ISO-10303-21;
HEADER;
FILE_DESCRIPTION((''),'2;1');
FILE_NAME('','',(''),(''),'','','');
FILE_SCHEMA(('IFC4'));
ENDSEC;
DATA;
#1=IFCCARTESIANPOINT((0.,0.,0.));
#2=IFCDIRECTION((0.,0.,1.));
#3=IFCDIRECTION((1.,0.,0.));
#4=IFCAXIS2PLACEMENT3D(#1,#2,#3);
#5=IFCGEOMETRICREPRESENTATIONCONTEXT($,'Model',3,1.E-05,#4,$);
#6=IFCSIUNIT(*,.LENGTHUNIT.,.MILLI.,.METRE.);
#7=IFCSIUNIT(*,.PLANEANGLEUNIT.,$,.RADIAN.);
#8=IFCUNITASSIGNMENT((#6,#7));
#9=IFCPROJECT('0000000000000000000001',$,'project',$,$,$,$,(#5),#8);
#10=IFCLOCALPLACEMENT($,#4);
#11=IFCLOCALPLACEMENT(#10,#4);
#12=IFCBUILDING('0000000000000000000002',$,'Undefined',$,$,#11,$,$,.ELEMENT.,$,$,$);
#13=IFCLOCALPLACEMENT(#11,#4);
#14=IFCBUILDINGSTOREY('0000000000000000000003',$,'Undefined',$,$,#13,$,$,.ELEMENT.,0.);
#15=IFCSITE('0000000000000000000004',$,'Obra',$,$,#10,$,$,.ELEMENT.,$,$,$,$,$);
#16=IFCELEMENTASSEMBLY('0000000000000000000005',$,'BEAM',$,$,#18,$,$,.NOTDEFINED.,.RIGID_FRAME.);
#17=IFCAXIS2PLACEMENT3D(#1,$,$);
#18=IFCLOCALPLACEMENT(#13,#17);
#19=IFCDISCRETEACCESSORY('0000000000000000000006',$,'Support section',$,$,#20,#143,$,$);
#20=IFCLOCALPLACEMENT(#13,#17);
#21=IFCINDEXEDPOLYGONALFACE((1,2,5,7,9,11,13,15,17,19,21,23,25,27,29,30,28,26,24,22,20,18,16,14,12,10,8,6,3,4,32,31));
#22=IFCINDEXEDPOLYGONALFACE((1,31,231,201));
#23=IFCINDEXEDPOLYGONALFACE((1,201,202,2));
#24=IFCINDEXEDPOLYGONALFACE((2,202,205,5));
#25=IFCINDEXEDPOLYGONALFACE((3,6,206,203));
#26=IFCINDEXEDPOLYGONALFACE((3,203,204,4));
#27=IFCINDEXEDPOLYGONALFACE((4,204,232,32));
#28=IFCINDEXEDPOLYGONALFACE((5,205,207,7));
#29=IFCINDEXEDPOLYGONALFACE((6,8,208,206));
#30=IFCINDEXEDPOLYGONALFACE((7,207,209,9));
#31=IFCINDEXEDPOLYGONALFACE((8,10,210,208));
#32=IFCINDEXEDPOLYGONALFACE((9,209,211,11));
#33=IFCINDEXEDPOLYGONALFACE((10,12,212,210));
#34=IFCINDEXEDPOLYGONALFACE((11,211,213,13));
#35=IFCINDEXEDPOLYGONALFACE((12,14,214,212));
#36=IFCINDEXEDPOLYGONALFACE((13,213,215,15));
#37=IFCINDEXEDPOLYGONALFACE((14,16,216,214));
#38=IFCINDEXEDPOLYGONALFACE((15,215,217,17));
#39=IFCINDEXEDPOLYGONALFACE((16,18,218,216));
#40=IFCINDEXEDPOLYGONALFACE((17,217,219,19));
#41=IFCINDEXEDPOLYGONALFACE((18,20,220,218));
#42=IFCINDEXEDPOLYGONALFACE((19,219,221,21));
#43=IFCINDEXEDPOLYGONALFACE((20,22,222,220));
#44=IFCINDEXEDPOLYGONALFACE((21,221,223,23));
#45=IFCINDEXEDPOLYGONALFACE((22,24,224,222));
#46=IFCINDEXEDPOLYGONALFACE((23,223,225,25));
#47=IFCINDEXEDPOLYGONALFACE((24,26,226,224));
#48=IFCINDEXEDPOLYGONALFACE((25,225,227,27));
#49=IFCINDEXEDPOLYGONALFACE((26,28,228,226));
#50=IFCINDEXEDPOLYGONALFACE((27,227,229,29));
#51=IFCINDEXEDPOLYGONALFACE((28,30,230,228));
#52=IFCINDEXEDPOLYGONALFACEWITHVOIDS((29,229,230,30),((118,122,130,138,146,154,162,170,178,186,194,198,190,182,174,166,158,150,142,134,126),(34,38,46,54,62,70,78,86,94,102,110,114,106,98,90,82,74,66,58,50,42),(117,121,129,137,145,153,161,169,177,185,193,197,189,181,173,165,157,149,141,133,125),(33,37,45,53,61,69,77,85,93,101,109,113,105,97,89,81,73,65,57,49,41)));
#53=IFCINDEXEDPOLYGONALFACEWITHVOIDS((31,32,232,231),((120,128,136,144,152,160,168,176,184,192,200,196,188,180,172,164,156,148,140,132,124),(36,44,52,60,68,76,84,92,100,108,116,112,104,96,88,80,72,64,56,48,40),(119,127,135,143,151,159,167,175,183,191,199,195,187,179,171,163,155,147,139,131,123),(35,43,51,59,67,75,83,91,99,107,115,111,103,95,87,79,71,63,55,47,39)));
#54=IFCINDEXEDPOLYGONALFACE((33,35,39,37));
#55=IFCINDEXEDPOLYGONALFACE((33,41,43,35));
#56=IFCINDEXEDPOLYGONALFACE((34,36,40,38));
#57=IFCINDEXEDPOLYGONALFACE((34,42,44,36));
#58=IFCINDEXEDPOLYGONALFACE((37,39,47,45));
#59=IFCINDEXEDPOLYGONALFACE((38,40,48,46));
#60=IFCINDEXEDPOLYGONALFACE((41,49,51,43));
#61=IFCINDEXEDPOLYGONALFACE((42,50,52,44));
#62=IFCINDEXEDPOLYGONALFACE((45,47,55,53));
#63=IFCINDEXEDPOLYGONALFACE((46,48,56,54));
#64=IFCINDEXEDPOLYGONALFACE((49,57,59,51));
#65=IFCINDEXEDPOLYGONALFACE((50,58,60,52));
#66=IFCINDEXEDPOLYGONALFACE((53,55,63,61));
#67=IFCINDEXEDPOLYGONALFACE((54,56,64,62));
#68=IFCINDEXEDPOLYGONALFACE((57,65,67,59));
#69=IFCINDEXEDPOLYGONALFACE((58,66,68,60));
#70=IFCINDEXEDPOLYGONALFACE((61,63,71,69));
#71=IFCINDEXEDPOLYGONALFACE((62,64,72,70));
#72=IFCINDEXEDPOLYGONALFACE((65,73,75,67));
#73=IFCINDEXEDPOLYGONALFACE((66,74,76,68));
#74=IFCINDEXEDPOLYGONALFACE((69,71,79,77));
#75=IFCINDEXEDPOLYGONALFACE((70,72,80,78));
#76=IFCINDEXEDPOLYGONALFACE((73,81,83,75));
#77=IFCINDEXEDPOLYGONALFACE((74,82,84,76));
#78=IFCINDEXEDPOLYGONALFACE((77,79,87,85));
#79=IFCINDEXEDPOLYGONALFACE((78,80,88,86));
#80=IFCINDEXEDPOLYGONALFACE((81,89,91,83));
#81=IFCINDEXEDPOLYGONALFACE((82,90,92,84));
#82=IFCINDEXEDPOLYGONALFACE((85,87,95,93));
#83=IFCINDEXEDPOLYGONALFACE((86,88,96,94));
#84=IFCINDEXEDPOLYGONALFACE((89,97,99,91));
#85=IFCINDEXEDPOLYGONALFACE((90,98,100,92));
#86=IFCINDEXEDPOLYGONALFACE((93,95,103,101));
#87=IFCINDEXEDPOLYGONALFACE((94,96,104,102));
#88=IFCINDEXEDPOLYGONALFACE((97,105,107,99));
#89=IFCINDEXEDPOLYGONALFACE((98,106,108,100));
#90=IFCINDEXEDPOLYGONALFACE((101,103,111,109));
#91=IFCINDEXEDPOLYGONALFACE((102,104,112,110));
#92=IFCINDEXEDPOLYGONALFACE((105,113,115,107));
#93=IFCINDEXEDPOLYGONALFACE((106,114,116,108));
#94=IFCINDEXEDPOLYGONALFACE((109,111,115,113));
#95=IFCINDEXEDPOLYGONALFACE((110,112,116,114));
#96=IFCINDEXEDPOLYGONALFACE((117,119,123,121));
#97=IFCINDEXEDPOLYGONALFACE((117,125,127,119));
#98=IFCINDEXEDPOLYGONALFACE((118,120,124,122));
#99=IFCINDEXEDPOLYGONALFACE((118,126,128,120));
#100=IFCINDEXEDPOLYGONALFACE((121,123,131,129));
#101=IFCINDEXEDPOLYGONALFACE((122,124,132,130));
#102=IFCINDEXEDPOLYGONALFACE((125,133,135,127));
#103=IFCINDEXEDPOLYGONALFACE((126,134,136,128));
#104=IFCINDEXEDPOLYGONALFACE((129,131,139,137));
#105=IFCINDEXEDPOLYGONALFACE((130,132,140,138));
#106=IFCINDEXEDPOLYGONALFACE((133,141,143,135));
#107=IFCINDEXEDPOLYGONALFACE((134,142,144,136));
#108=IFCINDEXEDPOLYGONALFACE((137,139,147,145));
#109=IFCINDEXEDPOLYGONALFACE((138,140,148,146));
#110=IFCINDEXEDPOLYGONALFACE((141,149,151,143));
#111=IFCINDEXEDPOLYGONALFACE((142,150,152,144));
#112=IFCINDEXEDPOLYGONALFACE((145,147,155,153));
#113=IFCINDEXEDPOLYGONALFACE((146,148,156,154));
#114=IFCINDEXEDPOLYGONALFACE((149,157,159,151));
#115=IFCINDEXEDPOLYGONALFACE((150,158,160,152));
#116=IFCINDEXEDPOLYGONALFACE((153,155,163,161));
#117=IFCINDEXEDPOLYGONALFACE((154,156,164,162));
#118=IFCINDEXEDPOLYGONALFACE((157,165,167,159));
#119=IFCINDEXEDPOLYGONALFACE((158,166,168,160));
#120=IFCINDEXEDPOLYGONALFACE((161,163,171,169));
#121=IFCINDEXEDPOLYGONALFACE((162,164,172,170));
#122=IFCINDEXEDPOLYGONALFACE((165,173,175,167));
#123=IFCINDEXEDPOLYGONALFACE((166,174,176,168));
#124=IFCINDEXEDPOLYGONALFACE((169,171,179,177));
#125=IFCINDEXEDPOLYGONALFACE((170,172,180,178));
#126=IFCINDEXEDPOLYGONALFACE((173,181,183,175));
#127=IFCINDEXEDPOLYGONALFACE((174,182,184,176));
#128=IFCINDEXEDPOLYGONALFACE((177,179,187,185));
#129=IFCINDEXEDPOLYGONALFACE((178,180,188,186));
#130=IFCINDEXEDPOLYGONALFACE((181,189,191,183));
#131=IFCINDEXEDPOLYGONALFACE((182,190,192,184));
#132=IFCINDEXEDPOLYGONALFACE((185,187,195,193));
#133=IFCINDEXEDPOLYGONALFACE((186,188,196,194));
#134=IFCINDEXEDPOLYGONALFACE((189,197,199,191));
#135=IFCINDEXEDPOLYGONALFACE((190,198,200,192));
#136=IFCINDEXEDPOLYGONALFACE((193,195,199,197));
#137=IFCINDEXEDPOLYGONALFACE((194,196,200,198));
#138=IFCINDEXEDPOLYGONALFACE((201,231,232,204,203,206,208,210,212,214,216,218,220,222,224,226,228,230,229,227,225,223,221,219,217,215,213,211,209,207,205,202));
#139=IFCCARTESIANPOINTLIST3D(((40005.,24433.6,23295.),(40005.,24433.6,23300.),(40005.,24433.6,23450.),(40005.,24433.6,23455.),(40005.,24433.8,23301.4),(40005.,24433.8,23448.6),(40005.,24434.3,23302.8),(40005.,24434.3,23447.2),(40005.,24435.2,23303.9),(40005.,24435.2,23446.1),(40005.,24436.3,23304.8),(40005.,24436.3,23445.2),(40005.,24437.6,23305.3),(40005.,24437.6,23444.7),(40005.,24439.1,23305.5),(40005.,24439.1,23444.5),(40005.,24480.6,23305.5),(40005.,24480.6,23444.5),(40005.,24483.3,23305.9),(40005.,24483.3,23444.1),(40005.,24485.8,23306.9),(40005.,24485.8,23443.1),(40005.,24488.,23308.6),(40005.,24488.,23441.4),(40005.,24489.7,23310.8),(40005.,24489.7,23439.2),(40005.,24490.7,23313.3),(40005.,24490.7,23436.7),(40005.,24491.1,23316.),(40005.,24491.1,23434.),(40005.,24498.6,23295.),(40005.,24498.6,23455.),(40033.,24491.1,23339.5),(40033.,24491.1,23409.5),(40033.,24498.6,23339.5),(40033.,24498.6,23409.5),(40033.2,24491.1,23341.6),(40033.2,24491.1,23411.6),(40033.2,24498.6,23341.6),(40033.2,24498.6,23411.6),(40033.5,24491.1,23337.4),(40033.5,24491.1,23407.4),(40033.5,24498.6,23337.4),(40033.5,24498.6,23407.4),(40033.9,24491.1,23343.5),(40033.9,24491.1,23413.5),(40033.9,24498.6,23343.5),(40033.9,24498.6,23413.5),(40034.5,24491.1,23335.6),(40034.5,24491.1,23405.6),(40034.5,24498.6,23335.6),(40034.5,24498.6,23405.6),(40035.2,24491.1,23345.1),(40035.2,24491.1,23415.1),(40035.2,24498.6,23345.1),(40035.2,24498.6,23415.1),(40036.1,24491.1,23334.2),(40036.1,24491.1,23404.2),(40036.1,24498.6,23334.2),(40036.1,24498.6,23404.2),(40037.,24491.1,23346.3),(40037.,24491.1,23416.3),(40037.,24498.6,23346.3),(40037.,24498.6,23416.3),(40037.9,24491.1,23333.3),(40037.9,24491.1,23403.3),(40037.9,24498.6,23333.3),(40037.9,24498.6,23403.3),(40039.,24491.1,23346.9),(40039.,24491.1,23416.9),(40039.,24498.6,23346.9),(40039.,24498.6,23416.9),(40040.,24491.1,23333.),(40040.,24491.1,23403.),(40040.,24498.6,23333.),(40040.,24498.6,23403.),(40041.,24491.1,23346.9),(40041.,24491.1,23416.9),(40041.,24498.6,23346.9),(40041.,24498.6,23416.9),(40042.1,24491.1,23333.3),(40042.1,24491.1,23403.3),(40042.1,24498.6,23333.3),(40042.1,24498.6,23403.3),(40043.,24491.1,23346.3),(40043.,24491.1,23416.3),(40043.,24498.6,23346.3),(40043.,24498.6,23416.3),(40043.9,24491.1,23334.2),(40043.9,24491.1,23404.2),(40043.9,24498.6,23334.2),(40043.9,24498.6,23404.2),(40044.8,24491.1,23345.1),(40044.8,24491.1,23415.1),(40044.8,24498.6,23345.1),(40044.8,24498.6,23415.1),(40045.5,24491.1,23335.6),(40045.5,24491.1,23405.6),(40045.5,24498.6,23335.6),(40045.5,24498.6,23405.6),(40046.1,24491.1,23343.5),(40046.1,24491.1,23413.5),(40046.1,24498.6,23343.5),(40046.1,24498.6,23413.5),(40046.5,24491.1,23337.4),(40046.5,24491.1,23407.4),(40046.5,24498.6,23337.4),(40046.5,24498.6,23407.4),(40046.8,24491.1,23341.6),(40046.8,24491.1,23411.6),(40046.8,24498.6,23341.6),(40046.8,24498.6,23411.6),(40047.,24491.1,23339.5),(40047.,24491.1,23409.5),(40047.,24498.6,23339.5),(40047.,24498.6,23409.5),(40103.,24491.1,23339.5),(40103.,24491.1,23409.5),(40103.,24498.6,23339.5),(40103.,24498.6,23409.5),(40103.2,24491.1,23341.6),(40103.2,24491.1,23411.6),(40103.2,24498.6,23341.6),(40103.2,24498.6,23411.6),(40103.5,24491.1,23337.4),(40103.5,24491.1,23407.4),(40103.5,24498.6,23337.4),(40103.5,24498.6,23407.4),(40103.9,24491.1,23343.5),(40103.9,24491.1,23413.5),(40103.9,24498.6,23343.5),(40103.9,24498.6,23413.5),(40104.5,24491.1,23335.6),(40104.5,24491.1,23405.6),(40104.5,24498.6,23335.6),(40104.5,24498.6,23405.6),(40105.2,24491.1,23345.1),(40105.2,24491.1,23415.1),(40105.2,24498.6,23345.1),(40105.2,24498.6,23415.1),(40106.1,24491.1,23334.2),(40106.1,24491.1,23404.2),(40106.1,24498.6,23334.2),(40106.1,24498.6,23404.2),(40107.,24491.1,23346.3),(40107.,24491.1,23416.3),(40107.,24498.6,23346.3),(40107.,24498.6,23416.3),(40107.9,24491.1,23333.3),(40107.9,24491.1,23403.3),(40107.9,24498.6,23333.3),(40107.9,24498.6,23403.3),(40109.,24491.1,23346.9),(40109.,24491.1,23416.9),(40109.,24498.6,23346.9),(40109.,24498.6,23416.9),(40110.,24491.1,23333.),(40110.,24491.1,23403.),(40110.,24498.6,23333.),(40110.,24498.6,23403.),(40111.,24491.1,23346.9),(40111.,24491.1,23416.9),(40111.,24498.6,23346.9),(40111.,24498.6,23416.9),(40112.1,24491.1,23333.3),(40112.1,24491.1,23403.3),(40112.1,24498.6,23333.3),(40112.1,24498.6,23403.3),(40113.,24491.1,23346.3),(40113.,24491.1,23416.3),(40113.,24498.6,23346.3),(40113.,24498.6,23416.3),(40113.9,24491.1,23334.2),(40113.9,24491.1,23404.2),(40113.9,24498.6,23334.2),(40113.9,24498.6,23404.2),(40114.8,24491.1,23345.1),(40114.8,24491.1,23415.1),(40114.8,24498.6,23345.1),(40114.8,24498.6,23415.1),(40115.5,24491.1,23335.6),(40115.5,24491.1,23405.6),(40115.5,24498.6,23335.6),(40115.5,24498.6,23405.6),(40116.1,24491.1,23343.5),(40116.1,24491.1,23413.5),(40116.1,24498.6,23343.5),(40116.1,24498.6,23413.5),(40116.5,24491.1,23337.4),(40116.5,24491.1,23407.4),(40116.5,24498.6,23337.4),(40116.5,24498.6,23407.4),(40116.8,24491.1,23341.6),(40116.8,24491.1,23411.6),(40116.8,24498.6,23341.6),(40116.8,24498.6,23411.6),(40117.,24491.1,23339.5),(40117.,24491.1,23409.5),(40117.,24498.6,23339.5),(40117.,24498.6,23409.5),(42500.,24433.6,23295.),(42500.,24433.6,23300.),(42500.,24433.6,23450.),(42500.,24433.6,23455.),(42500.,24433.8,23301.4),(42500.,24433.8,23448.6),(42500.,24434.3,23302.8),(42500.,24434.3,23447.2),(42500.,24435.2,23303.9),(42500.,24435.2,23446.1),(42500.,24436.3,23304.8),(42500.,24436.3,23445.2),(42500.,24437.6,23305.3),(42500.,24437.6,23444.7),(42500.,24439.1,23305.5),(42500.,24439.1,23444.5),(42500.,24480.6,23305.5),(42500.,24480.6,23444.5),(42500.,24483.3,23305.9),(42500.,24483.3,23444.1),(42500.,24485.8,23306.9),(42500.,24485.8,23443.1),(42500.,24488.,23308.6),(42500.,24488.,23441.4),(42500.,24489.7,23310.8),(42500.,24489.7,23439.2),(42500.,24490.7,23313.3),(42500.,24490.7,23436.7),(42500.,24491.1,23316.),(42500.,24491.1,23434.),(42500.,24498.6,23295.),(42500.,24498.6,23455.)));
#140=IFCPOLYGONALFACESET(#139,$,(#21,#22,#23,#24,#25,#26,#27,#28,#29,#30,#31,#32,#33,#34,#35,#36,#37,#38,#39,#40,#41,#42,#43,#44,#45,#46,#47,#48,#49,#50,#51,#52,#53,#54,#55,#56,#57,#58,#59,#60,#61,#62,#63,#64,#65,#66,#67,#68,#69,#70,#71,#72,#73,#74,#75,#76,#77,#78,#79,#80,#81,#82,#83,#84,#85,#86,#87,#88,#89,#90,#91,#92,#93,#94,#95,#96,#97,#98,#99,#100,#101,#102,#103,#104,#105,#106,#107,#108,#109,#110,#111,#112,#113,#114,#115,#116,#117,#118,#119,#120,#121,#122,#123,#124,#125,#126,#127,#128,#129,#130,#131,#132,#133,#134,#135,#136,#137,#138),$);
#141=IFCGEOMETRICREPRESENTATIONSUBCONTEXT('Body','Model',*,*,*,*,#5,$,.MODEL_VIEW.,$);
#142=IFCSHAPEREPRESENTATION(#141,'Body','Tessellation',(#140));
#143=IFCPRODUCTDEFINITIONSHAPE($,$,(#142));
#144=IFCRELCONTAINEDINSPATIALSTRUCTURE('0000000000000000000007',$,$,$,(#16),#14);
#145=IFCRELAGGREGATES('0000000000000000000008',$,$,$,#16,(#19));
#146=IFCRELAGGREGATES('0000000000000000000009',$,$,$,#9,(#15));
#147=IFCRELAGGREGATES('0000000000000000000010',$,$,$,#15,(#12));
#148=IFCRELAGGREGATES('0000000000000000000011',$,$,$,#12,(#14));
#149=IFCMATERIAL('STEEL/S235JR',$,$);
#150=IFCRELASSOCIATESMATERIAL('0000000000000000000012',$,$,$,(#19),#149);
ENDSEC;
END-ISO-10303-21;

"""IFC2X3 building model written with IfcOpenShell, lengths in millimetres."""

from ifc_helpers import new_model, si_unit, frame, origin_with_axes, origin_2d_with_axis, place, context, subcontext, project, spatial, circle, u_section, extrude, clip, halfspace, source, transform, mapped, material, element, aggregate, save


model = new_model("IFC2X3")

# Units and contexts
model_context = context("Model", 3, precision=1e-05, world=origin_with_axes())
body_context = subcontext(model_context, "Body", "Model", "MODEL_VIEW")
ifc_project = project(units=[si_unit("LENGTHUNIT", "METRE", prefix="MILLI"), si_unit("PLANEANGLEUNIT", "RADIAN")], contexts=[model_context])

# Site, building, storey
site_placement = place(None, origin_with_axes())
site = spatial("IfcSite", under=ifc_project, at=site_placement, Name="Obra", CompositionType="ELEMENT")
building_placement = place(site_placement, origin_with_axes())
building = spatial("IfcBuilding", under=site, at=building_placement, Name="Undefined", CompositionType="ELEMENT")
storey_placement = place(building_placement, origin_with_axes())
storey = spatial("IfcBuildingStorey", under=building, at=storey_placement, Name="Undefined", CompositionType="ELEMENT", Elevation=0.0)

# Element assembly
assembly_1_placement = place(storey_placement, origin_with_axes())
assembly_1 = element("IfcElementAssembly", 1, at=assembly_1_placement, inside=storey, Name="BEAM", AssemblyPlace="NOTDEFINED", PredefinedType="RIGID_FRAME")

# Shared definitions
ifc_material_1 = material(Name="STEEL/S235JR")

# Discrete accessory, opening
discrete_accessory_1_placement = place(assembly_1_placement, frame((40000.0, 24466.1, 23375.0), z_axis=(0.0, 0.0, 1.0), x_axis=(1.0, 0.0, 0.0)))
discrete_accessory_1 = element("IfcDiscreteAccessory", 2, at=discrete_accessory_1_placement, material=ifc_material_1, Name="Support section", context=body_context, shape_type="Clipping", body=[
    clip(extrude(u_section(Depth=160.0, FlangeWidth=65.0, WebThickness=7.5, FlangeThickness=10.5, FilletRadius=10.5, EdgeRadius=5.5, at=origin_2d_with_axis()), frame((2500.0, 0.0, 0.0), z_axis=(-1.0, 0.0, 0.0), x_axis=(0.0, -1.0, 0.0)), (0.0, 0.0, 1.0), 2495.0), halfspace(frame((5.0, 0.0, 166.3), z_axis=(-1.0, 0.0, 0.0), x_axis=(0.0, -1.0, 0.0)), False)),
])
shared_shape_1 = source(origin_with_axes(), body_context, "Body", "SweptSolid", [
    extrude(circle(Radius=7.0, at=origin_2d_with_axis()), frame((0.0, -3.9, 0.0), z_axis=(0.0, 1.0, 0.0), x_axis=(1.0, 0.0, 0.0)), (0.0, 0.0, 1.0), 7.7),
])
opening_1_placement = place(assembly_1_placement, frame((40040.0, 24494.8, 23410.0), z_axis=(1.0, 0.0, 0.0), x_axis=(0.0, 0.0, -1.0)))
element("IfcOpeningElement", 3, at=opening_1_placement, cuts=discrete_accessory_1, ObjectType="Opening", context=body_context, shape_type="MappedRepresentation", body=[
    mapped(shared_shape_1, transform((0.0, 0.0, 0.0))),
    mapped(shared_shape_1, transform((0.0, 0.0, 70.0))),
    mapped(shared_shape_1, transform((70.0, 0.0, 0.0))),
    mapped(shared_shape_1, transform((70.0, 0.0, 70.0))),
])
aggregate(assembly_1, [discrete_accessory_1])

save(model, "model.ifc")
